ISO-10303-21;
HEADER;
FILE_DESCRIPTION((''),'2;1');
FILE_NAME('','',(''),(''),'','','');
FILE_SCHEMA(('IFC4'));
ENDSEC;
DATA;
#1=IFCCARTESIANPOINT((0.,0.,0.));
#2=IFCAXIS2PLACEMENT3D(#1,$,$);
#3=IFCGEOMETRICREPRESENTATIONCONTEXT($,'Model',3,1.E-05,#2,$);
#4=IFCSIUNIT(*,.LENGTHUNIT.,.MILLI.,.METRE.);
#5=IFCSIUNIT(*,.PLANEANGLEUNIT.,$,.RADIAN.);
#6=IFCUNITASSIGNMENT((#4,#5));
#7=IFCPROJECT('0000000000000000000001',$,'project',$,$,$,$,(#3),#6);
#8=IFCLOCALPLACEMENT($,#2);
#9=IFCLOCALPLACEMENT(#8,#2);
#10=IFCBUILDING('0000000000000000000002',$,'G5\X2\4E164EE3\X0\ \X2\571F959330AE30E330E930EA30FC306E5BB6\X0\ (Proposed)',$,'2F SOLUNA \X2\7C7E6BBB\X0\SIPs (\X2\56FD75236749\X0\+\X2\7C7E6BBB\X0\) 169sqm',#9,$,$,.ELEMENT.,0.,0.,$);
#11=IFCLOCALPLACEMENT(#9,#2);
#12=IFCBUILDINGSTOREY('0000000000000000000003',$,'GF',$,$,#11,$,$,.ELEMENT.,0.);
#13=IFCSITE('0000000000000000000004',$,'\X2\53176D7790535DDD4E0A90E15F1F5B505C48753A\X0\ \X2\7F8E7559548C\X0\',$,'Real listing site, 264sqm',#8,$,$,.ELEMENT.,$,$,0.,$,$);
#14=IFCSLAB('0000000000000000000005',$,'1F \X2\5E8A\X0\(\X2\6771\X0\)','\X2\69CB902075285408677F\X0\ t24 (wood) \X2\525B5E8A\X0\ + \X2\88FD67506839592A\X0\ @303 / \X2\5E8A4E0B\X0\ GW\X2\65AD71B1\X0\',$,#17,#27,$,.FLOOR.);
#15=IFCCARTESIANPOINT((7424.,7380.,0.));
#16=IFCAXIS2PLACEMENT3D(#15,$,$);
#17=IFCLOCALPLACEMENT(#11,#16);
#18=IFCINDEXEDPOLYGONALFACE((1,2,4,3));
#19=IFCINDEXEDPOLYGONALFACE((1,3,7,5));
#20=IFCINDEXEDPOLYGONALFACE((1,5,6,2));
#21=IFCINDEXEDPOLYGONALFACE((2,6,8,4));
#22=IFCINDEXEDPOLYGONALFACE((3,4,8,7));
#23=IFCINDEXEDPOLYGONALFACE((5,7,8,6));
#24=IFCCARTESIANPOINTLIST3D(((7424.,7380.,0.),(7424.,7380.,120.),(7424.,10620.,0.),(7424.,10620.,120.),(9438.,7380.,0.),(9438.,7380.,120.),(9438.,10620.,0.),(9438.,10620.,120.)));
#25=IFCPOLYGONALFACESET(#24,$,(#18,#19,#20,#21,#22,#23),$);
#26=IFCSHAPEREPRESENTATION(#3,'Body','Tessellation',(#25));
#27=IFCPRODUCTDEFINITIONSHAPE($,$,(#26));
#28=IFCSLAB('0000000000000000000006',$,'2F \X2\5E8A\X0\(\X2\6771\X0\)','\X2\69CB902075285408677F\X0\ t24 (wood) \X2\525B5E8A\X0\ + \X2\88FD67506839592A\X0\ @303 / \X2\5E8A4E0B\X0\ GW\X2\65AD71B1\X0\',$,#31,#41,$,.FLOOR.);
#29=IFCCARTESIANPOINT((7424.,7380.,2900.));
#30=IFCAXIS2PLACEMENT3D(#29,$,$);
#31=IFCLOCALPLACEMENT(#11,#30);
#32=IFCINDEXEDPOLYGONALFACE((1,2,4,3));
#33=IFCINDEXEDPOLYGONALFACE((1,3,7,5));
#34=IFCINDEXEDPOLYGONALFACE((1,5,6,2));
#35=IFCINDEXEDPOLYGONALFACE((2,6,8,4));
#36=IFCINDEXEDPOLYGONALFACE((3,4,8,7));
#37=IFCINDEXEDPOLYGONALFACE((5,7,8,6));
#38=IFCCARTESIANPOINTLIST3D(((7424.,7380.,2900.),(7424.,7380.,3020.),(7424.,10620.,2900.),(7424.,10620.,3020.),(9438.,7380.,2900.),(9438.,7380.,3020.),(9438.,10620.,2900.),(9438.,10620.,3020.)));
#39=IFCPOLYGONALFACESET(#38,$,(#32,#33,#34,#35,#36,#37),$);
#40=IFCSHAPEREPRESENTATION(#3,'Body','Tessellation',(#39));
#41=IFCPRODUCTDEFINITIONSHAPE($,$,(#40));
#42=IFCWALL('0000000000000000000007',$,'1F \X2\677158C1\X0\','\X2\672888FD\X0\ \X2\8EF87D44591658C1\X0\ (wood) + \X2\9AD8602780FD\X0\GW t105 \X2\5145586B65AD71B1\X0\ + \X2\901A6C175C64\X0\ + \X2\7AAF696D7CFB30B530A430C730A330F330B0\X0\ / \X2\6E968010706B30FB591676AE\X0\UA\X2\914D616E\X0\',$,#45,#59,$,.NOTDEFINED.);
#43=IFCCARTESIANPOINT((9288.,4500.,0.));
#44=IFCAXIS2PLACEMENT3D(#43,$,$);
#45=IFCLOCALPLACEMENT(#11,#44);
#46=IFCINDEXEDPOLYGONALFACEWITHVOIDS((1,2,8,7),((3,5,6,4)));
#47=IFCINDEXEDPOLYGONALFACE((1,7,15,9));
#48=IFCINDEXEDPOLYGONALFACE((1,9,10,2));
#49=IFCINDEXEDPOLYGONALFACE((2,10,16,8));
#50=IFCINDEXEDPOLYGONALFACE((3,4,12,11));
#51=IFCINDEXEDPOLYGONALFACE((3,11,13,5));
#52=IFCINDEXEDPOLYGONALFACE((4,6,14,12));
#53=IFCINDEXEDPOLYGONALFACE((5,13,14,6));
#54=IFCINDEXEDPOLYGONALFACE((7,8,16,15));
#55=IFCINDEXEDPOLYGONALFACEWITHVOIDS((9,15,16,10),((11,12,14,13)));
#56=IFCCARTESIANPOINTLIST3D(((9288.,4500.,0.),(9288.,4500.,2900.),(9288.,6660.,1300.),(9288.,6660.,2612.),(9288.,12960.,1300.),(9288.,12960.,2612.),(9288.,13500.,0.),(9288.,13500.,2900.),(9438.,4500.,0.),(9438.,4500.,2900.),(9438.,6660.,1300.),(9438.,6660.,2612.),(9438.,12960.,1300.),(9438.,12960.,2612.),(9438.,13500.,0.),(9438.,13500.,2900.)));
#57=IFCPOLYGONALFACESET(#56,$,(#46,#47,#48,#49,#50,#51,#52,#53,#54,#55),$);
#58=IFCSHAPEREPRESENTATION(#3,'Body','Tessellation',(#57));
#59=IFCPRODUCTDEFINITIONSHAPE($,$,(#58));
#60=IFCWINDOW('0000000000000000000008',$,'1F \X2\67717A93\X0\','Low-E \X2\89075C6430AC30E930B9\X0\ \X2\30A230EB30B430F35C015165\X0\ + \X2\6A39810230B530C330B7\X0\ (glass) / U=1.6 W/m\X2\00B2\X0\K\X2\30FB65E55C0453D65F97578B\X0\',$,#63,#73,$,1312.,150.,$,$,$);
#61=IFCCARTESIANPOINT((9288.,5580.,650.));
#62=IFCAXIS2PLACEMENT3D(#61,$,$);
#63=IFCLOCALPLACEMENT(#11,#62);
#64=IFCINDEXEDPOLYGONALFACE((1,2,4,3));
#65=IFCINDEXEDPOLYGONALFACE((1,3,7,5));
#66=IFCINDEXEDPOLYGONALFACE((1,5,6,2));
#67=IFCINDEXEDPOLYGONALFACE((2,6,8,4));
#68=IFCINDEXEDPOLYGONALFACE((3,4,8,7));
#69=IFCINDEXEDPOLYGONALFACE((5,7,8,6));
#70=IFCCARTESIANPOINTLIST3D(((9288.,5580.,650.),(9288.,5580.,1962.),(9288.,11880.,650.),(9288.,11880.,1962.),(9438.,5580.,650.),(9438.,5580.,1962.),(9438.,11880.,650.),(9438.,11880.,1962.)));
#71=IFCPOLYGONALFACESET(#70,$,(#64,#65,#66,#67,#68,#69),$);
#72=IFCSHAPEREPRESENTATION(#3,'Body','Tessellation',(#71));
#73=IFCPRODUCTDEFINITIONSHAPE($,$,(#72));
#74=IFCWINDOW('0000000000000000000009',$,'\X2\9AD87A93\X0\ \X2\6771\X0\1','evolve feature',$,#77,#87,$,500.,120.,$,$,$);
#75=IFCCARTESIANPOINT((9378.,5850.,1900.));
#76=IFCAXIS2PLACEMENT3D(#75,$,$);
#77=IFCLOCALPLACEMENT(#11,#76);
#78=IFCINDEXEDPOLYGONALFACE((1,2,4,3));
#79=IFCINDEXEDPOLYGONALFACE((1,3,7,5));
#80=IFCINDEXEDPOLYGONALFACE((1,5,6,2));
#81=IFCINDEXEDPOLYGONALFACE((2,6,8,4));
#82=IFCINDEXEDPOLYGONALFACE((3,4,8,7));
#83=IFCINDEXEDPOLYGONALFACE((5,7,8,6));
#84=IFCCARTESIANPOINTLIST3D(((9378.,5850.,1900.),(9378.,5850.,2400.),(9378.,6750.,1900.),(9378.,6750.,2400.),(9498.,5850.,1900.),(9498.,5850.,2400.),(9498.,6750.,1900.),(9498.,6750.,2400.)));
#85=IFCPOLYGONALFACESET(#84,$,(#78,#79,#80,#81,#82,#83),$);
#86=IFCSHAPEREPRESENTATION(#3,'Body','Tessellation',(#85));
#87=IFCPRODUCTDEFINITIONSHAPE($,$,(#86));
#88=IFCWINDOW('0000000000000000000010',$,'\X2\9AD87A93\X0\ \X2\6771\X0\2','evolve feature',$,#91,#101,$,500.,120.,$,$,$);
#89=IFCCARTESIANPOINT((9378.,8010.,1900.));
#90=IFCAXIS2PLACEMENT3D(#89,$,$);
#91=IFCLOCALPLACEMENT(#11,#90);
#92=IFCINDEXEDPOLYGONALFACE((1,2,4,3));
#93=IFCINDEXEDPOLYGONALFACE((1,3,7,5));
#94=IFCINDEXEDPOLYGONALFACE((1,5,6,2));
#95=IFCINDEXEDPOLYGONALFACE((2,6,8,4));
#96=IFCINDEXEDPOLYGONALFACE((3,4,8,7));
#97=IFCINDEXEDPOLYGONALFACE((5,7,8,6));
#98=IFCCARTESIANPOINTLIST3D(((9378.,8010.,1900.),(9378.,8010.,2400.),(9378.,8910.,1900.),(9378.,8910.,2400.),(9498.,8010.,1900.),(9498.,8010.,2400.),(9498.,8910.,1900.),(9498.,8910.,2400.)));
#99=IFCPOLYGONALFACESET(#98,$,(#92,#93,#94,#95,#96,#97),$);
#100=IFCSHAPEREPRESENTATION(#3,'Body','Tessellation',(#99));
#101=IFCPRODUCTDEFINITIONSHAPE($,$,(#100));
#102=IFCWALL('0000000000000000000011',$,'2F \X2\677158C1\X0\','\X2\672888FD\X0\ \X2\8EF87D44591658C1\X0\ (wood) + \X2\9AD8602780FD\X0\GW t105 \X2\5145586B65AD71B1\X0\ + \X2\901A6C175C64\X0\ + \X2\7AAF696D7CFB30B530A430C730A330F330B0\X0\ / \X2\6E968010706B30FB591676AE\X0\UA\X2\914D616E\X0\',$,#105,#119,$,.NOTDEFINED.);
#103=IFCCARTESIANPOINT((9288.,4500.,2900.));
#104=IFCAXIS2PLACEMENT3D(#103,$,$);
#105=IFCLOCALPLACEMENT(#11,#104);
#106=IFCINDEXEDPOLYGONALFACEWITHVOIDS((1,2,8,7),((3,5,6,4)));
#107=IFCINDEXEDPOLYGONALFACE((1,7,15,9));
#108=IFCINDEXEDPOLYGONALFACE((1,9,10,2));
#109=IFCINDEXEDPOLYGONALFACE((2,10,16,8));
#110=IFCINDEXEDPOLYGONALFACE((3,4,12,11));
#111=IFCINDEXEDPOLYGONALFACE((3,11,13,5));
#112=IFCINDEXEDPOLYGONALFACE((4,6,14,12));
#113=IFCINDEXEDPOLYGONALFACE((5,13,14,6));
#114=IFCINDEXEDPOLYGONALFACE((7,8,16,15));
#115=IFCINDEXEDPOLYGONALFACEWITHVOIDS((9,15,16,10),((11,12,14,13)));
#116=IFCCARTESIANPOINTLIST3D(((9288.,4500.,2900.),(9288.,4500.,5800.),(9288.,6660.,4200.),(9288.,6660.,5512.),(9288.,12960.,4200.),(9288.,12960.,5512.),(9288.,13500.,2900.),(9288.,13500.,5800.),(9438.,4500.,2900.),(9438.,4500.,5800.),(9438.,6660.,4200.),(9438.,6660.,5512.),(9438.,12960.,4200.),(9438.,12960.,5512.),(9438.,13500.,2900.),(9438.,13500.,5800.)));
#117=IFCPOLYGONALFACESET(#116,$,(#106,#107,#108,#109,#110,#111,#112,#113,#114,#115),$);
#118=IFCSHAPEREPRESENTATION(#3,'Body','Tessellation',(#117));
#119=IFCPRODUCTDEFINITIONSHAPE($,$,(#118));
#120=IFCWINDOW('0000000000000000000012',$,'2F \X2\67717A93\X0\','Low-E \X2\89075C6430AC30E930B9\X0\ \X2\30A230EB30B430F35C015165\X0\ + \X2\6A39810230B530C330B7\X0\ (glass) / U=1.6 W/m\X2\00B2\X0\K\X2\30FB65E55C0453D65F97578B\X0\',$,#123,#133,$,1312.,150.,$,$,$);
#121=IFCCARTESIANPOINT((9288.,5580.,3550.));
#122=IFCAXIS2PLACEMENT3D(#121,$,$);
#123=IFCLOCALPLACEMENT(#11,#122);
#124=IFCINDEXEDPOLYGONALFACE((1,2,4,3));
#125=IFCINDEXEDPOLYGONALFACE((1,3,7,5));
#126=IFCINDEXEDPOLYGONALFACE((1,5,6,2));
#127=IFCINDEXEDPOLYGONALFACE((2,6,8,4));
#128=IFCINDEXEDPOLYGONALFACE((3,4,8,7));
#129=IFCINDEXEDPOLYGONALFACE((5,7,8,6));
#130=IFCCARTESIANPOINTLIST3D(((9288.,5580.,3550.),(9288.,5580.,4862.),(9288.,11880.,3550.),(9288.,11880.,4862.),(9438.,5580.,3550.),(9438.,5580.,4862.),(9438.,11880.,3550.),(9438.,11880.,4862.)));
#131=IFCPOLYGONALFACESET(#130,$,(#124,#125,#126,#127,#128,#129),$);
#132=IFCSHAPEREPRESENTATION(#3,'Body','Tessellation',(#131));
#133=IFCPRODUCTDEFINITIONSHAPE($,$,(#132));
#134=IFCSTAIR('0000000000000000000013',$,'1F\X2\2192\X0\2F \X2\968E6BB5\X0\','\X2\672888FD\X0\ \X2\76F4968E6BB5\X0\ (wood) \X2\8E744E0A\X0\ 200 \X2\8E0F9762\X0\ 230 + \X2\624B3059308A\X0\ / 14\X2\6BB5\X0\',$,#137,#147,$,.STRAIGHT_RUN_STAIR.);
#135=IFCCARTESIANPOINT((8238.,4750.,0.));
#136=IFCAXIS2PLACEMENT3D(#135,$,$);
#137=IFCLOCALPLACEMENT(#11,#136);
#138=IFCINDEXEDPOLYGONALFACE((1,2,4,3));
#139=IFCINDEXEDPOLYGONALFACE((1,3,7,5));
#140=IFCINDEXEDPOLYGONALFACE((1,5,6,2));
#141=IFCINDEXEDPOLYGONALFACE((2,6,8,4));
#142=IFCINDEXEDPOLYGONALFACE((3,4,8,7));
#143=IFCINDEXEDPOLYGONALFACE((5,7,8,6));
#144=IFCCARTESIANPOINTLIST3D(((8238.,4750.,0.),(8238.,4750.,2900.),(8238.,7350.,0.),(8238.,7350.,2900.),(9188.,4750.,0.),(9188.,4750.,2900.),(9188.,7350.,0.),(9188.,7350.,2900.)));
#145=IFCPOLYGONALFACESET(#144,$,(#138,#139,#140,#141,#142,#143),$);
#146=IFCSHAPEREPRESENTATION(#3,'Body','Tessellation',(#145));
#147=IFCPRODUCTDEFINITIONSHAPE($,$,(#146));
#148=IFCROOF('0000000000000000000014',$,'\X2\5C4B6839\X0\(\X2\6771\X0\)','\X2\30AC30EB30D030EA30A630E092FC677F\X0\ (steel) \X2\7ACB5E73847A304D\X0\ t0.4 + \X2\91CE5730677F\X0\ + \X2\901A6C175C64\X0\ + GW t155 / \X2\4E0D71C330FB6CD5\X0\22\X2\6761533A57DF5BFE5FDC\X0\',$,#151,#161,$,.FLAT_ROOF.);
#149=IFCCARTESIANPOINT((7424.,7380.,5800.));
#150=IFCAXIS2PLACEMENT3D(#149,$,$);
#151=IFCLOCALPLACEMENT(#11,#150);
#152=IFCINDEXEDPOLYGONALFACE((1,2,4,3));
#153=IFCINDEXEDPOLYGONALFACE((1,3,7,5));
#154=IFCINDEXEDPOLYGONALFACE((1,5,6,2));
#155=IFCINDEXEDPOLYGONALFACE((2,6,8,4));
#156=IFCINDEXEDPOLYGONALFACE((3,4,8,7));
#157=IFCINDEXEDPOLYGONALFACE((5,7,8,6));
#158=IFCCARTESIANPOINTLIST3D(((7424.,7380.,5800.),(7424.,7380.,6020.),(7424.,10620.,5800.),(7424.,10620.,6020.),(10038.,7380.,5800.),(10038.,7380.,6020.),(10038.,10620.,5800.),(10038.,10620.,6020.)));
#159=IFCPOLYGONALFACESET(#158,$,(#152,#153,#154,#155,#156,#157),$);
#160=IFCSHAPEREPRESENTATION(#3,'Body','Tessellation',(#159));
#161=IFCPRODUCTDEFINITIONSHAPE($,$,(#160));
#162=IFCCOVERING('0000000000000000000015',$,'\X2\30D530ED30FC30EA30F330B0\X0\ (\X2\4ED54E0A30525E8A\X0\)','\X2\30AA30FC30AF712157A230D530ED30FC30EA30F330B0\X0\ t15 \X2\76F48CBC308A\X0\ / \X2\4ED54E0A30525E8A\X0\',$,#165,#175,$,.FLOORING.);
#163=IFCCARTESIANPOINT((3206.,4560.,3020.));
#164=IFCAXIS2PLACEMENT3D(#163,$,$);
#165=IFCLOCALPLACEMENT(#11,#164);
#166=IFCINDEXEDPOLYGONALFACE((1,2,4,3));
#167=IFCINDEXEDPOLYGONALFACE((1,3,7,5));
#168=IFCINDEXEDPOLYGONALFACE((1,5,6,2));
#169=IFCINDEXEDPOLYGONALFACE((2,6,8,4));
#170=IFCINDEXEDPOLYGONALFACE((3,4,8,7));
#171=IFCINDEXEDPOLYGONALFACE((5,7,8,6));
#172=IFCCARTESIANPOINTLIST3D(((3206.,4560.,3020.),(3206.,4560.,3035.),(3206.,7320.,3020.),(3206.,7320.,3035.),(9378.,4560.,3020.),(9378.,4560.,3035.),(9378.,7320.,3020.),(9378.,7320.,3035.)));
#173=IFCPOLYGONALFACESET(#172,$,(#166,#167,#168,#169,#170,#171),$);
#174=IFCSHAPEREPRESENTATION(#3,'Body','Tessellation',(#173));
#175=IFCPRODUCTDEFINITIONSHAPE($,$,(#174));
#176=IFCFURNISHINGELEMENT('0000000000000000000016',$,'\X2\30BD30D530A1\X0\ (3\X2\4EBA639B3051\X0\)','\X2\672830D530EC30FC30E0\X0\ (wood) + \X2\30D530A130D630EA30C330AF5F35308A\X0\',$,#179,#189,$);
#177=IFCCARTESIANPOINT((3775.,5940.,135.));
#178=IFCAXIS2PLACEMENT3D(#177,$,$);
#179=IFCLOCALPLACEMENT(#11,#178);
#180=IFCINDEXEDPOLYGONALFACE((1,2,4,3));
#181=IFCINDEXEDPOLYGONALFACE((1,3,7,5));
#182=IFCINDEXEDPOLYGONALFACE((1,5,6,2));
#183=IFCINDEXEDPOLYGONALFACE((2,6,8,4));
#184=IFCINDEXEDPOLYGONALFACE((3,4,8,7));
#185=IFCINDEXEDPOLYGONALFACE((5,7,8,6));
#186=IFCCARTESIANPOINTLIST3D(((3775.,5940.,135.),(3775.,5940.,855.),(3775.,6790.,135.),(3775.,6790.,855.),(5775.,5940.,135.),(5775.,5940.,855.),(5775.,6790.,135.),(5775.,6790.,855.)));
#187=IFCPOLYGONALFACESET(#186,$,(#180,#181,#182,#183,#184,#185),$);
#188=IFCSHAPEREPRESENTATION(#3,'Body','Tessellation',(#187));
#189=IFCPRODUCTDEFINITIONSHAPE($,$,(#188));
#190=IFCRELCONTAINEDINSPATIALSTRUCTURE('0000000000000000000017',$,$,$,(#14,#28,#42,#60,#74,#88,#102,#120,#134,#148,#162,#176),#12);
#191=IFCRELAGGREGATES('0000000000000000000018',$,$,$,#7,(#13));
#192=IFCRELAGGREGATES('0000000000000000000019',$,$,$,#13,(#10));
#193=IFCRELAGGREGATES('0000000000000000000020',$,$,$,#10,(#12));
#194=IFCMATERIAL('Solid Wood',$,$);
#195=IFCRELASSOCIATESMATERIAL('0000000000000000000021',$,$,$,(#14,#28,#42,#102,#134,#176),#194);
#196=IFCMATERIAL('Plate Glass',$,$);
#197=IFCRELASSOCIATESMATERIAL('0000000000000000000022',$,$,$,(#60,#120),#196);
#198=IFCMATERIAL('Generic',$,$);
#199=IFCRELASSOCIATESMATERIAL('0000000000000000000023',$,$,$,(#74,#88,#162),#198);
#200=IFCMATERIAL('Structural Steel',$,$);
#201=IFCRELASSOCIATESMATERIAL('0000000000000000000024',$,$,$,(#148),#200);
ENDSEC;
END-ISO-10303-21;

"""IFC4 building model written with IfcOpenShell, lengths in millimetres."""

from ifc_helpers import new_model, si_unit, frame, frame_2d, origin, place, context, project, spatial, rectangle, extrude, material, element, fill, save


model = new_model("IFC4")

# Units and contexts
model_context = context("Model", 3, precision=1e-05, world=origin())
ifc_project = project(units=[si_unit("LENGTHUNIT", "METRE", prefix="MILLI"), si_unit("PLANEANGLEUNIT", "RADIAN")], contexts=[model_context])

# Site, building, storey
site_placement = place(None, origin())
site = spatial("IfcSite", under=ifc_project, at=site_placement, Name="北海道川上郡弟子屈町 美留和", ObjectType="Real listing site, 264sqm", CompositionType="ELEMENT", RefElevation=0.0)
building_placement = place(site_placement, origin())
building = spatial("IfcBuilding", under=site, at=building_placement, Name="G5世代 土間ギャラリーの家 (Proposed)", ObjectType="2F SOLUNA 籾殻SIPs (国産杉+籾殻) 169sqm", CompositionType="ELEMENT", ElevationOfRefHeight=0.0, ElevationOfTerrain=0.0)
storey_placement = place(building_placement, origin())
storey = spatial("IfcBuildingStorey", under=building, at=storey_placement, Name="GF", CompositionType="ELEMENT", Elevation=0.0)

# Slabs
ifc_material_1 = material(Name="Solid Wood")
slab_1_placement = place(storey_placement, frame((7424.0, 7380.0, 0.0)))
element("IfcSlab", 1, at=slab_1_placement, inside=storey, material=ifc_material_1, Name="1F 床(東)", Description="構造用合板 t24 (wood) 剛床 + 製材根太 @303 / 床下 GW断熱", PredefinedType="FLOOR", context=model_context, shape_type="SweptSolid", body=[
    extrude(rectangle(XDim=2014.0, YDim=3240.0, at=frame_2d((1007.0, 1620.0))), frame((7424.0, 7380.0, 0.0)), (0.0, 0.0, 1.0), 120.0),
])
slab_2_placement = place(storey_placement, frame((7424.0, 7380.0, 2900.0)))
element("IfcSlab", 2, at=slab_2_placement, inside=storey, material=ifc_material_1, Name="2F 床(東)", Description="構造用合板 t24 (wood) 剛床 + 製材根太 @303 / 床下 GW断熱", PredefinedType="FLOOR", context=model_context, shape_type="SweptSolid", body=[
    extrude(rectangle(XDim=2014.0, YDim=3240.0, at=frame_2d((1007.0, 1620.0))), frame((7424.0, 7380.0, 2900.0)), (0.0, 0.0, 1.0), 120.0),
])

# Wall, openings, windows
wall_1_placement = place(storey_placement, frame((9288.0, 4500.0, 0.0)))
wall_1 = element("IfcWall", 3, at=wall_1_placement, inside=storey, material=ifc_material_1, Name="1F 東壁", Description="木製 軸組外壁 (wood) + 高性能GW t105 充填断熱 + 通気層 + 窯業系サイディング / 準耐火・外皮UA配慮", PredefinedType="NOTDEFINED", context=model_context, shape_type="SweptSolid", body=[
    extrude(rectangle(XDim=150.0, YDim=9000.0, at=frame_2d((75.0, 4500.0))), frame((9288.0, 4500.0, 0.0)), (0.0, 0.0, 1.0), 2900.0),
])
opening_1_placement = place(storey_placement, frame((9288.0, 5580.0, 650.0)))
opening_1 = element("IfcOpeningElement", 4, at=opening_1_placement, cuts=wall_1, PredefinedType="NOTDEFINED", context=model_context, shape_type="SweptSolid", body=[
    extrude(rectangle(XDim=150.0, YDim=6300.0, at=frame_2d((75.0, 3150.0))), frame((9288.0, 5580.0, 650.0)), (0.0, 0.0, 1.0), 1312.0),
])
opening_2_placement = place(storey_placement, frame((9378.0, 5850.0, 1900.0)))
opening_2 = element("IfcOpeningElement", 5, at=opening_2_placement, cuts=wall_1, PredefinedType="NOTDEFINED", context=model_context, shape_type="SweptSolid", body=[
    extrude(rectangle(XDim=120.0, YDim=900.0, at=frame_2d((60.0, 450.0))), frame((9378.0, 5850.0, 1900.0)), (0.0, 0.0, 1.0), 500.0),
])
opening_3_placement = place(storey_placement, frame((9378.0, 8010.0, 1900.0)))
opening_3 = element("IfcOpeningElement", 6, at=opening_3_placement, cuts=wall_1, PredefinedType="NOTDEFINED", context=model_context, shape_type="SweptSolid", body=[
    extrude(rectangle(XDim=120.0, YDim=900.0, at=frame_2d((60.0, 450.0))), frame((9378.0, 8010.0, 1900.0)), (0.0, 0.0, 1.0), 500.0),
])
ifc_material_2 = material(Name="Plate Glass")
window_1_placement = place(storey_placement, frame((9288.0, 5580.0, 650.0)))
window_1 = element("IfcWindow", 7, at=window_1_placement, inside=storey, material=ifc_material_2, Name="1F 東窓", Description="Low-E 複層ガラス アルゴン封入 + 樹脂サッシ (glass) / U=1.6 W/m²K・日射取得型", OverallHeight=1312.0, OverallWidth=150.0, context=model_context, shape_type="SweptSolid", body=[
    extrude(rectangle(XDim=150.0, YDim=6300.0, at=frame_2d((75.0, 3150.0))), frame((9288.0, 5580.0, 650.0)), (0.0, 0.0, 1.0), 1312.0),
])
fill(opening_1, window_1)
ifc_material_3 = material(Name="Generic")
window_2_placement = place(storey_placement, frame((9378.0, 5850.0, 1900.0)))
window_2 = element("IfcWindow", 8, at=window_2_placement, inside=storey, material=ifc_material_3, Name="高窓 東1", Description="evolve feature", OverallHeight=500.0, OverallWidth=120.0, context=model_context, shape_type="SweptSolid", body=[
    extrude(rectangle(XDim=120.0, YDim=900.0, at=frame_2d((60.0, 450.0))), frame((9378.0, 5850.0, 1900.0)), (0.0, 0.0, 1.0), 500.0),
])
fill(opening_2, window_2)
window_3_placement = place(storey_placement, frame((9378.0, 8010.0, 1900.0)))
window_3 = element("IfcWindow", 9, at=window_3_placement, inside=storey, material=ifc_material_3, Name="高窓 東2", Description="evolve feature", OverallHeight=500.0, OverallWidth=120.0, context=model_context, shape_type="SweptSolid", body=[
    extrude(rectangle(XDim=120.0, YDim=900.0, at=frame_2d((60.0, 450.0))), frame((9378.0, 8010.0, 1900.0)), (0.0, 0.0, 1.0), 500.0),
])
fill(opening_3, window_3)

# Wall, opening, window
wall_2_placement = place(storey_placement, frame((9288.0, 4500.0, 2900.0)))
wall_2 = element("IfcWall", 10, at=wall_2_placement, inside=storey, material=ifc_material_1, Name="2F 東壁", Description="木製 軸組外壁 (wood) + 高性能GW t105 充填断熱 + 通気層 + 窯業系サイディング / 準耐火・外皮UA配慮", PredefinedType="NOTDEFINED", context=model_context, shape_type="SweptSolid", body=[
    extrude(rectangle(XDim=150.0, YDim=9000.0, at=frame_2d((75.0, 4500.0))), frame((9288.0, 4500.0, 2900.0)), (0.0, 0.0, 1.0), 2900.0),
])
opening_4_placement = place(storey_placement, frame((9288.0, 5580.0, 3550.0)))
opening_4 = element("IfcOpeningElement", 11, at=opening_4_placement, cuts=wall_2, PredefinedType="NOTDEFINED", context=model_context, shape_type="SweptSolid", body=[
    extrude(rectangle(XDim=150.0, YDim=6300.0, at=frame_2d((75.0, 3150.0))), frame((9288.0, 5580.0, 3550.0)), (0.0, 0.0, 1.0), 1312.0),
])
window_4_placement = place(storey_placement, frame((9288.0, 5580.0, 3550.0)))
window_4 = element("IfcWindow", 12, at=window_4_placement, inside=storey, material=ifc_material_2, Name="2F 東窓", Description="Low-E 複層ガラス アルゴン封入 + 樹脂サッシ (glass) / U=1.6 W/m²K・日射取得型", OverallHeight=1312.0, OverallWidth=150.0, context=model_context, shape_type="SweptSolid", body=[
    extrude(rectangle(XDim=150.0, YDim=6300.0, at=frame_2d((75.0, 3150.0))), frame((9288.0, 5580.0, 3550.0)), (0.0, 0.0, 1.0), 1312.0),
])
fill(opening_4, window_4)

# Stair
stair_placement = place(storey_placement, frame((8238.0, 4750.0, 0.0)))
element("IfcStair", 13, at=stair_placement, inside=storey, material=ifc_material_1, Name="1F→2F 階段", Description="木製 直階段 (wood) 蹴上 200 踏面 230 + 手すり / 14段", PredefinedType="STRAIGHT_RUN_STAIR", context=model_context, shape_type="SweptSolid", body=[
    extrude(rectangle(XDim=950.0, YDim=2600.0, at=frame_2d((475.0, 1300.0))), frame((8238.0, 4750.0, 0.0)), (0.0, 0.0, 1.0), 2900.0),
])

# Roof
ifc_material_4 = material(Name="Structural Steel")
roof_placement = place(storey_placement, frame((7424.0, 7380.0, 5800.0)))
element("IfcRoof", 14, at=roof_placement, inside=storey, material=ifc_material_4, Name="屋根(東)", Description="ガルバリウム鋼板 (steel) 立平葺き t0.4 + 野地板 + 通気層 + GW t155 / 不燃・法22条区域対応", PredefinedType="FLAT_ROOF", context=model_context, shape_type="SweptSolid", body=[
    extrude(rectangle(XDim=2614.0, YDim=3240.0, at=frame_2d((1307.0, 1620.0))), frame((7424.0, 7380.0, 5800.0)), (0.0, 0.0, 1.0), 220.0),
])

# Covering
covering_placement = place(storey_placement, frame((3206.0, 4560.0, 3020.0)))
element("IfcCovering", 15, at=covering_placement, inside=storey, material=ifc_material_3, Name="フローリング (仕上げ床)", Description="オーク無垢フローリング t15 直貼り / 仕上げ床", PredefinedType="FLOORING", context=model_context, shape_type="SweptSolid", body=[
    extrude(rectangle(XDim=6172.0, YDim=2760.0, at=frame_2d((3086.0, 1380.0))), frame((3206.0, 4560.0, 3020.0)), (0.0, 0.0, 1.0), 15.0),
])

# Furnishing element
furnishing_1_placement = place(storey_placement, frame((3775.0, 5940.0, 135.0)))
element("IfcFurnishingElement", 16, at=furnishing_1_placement, inside=storey, material=ifc_material_1, Name="ソファ (3人掛け)", Description="木フレーム (wood) + ファブリック張り", context=model_context, shape_type="SweptSolid", body=[
    extrude(rectangle(XDim=2000.0, YDim=850.0, at=frame_2d((1000.0, 425.0))), frame((3775.0, 5940.0, 135.0)), (0.0, 0.0, 1.0), 720.0),
])

save(model, "model.ifc")
